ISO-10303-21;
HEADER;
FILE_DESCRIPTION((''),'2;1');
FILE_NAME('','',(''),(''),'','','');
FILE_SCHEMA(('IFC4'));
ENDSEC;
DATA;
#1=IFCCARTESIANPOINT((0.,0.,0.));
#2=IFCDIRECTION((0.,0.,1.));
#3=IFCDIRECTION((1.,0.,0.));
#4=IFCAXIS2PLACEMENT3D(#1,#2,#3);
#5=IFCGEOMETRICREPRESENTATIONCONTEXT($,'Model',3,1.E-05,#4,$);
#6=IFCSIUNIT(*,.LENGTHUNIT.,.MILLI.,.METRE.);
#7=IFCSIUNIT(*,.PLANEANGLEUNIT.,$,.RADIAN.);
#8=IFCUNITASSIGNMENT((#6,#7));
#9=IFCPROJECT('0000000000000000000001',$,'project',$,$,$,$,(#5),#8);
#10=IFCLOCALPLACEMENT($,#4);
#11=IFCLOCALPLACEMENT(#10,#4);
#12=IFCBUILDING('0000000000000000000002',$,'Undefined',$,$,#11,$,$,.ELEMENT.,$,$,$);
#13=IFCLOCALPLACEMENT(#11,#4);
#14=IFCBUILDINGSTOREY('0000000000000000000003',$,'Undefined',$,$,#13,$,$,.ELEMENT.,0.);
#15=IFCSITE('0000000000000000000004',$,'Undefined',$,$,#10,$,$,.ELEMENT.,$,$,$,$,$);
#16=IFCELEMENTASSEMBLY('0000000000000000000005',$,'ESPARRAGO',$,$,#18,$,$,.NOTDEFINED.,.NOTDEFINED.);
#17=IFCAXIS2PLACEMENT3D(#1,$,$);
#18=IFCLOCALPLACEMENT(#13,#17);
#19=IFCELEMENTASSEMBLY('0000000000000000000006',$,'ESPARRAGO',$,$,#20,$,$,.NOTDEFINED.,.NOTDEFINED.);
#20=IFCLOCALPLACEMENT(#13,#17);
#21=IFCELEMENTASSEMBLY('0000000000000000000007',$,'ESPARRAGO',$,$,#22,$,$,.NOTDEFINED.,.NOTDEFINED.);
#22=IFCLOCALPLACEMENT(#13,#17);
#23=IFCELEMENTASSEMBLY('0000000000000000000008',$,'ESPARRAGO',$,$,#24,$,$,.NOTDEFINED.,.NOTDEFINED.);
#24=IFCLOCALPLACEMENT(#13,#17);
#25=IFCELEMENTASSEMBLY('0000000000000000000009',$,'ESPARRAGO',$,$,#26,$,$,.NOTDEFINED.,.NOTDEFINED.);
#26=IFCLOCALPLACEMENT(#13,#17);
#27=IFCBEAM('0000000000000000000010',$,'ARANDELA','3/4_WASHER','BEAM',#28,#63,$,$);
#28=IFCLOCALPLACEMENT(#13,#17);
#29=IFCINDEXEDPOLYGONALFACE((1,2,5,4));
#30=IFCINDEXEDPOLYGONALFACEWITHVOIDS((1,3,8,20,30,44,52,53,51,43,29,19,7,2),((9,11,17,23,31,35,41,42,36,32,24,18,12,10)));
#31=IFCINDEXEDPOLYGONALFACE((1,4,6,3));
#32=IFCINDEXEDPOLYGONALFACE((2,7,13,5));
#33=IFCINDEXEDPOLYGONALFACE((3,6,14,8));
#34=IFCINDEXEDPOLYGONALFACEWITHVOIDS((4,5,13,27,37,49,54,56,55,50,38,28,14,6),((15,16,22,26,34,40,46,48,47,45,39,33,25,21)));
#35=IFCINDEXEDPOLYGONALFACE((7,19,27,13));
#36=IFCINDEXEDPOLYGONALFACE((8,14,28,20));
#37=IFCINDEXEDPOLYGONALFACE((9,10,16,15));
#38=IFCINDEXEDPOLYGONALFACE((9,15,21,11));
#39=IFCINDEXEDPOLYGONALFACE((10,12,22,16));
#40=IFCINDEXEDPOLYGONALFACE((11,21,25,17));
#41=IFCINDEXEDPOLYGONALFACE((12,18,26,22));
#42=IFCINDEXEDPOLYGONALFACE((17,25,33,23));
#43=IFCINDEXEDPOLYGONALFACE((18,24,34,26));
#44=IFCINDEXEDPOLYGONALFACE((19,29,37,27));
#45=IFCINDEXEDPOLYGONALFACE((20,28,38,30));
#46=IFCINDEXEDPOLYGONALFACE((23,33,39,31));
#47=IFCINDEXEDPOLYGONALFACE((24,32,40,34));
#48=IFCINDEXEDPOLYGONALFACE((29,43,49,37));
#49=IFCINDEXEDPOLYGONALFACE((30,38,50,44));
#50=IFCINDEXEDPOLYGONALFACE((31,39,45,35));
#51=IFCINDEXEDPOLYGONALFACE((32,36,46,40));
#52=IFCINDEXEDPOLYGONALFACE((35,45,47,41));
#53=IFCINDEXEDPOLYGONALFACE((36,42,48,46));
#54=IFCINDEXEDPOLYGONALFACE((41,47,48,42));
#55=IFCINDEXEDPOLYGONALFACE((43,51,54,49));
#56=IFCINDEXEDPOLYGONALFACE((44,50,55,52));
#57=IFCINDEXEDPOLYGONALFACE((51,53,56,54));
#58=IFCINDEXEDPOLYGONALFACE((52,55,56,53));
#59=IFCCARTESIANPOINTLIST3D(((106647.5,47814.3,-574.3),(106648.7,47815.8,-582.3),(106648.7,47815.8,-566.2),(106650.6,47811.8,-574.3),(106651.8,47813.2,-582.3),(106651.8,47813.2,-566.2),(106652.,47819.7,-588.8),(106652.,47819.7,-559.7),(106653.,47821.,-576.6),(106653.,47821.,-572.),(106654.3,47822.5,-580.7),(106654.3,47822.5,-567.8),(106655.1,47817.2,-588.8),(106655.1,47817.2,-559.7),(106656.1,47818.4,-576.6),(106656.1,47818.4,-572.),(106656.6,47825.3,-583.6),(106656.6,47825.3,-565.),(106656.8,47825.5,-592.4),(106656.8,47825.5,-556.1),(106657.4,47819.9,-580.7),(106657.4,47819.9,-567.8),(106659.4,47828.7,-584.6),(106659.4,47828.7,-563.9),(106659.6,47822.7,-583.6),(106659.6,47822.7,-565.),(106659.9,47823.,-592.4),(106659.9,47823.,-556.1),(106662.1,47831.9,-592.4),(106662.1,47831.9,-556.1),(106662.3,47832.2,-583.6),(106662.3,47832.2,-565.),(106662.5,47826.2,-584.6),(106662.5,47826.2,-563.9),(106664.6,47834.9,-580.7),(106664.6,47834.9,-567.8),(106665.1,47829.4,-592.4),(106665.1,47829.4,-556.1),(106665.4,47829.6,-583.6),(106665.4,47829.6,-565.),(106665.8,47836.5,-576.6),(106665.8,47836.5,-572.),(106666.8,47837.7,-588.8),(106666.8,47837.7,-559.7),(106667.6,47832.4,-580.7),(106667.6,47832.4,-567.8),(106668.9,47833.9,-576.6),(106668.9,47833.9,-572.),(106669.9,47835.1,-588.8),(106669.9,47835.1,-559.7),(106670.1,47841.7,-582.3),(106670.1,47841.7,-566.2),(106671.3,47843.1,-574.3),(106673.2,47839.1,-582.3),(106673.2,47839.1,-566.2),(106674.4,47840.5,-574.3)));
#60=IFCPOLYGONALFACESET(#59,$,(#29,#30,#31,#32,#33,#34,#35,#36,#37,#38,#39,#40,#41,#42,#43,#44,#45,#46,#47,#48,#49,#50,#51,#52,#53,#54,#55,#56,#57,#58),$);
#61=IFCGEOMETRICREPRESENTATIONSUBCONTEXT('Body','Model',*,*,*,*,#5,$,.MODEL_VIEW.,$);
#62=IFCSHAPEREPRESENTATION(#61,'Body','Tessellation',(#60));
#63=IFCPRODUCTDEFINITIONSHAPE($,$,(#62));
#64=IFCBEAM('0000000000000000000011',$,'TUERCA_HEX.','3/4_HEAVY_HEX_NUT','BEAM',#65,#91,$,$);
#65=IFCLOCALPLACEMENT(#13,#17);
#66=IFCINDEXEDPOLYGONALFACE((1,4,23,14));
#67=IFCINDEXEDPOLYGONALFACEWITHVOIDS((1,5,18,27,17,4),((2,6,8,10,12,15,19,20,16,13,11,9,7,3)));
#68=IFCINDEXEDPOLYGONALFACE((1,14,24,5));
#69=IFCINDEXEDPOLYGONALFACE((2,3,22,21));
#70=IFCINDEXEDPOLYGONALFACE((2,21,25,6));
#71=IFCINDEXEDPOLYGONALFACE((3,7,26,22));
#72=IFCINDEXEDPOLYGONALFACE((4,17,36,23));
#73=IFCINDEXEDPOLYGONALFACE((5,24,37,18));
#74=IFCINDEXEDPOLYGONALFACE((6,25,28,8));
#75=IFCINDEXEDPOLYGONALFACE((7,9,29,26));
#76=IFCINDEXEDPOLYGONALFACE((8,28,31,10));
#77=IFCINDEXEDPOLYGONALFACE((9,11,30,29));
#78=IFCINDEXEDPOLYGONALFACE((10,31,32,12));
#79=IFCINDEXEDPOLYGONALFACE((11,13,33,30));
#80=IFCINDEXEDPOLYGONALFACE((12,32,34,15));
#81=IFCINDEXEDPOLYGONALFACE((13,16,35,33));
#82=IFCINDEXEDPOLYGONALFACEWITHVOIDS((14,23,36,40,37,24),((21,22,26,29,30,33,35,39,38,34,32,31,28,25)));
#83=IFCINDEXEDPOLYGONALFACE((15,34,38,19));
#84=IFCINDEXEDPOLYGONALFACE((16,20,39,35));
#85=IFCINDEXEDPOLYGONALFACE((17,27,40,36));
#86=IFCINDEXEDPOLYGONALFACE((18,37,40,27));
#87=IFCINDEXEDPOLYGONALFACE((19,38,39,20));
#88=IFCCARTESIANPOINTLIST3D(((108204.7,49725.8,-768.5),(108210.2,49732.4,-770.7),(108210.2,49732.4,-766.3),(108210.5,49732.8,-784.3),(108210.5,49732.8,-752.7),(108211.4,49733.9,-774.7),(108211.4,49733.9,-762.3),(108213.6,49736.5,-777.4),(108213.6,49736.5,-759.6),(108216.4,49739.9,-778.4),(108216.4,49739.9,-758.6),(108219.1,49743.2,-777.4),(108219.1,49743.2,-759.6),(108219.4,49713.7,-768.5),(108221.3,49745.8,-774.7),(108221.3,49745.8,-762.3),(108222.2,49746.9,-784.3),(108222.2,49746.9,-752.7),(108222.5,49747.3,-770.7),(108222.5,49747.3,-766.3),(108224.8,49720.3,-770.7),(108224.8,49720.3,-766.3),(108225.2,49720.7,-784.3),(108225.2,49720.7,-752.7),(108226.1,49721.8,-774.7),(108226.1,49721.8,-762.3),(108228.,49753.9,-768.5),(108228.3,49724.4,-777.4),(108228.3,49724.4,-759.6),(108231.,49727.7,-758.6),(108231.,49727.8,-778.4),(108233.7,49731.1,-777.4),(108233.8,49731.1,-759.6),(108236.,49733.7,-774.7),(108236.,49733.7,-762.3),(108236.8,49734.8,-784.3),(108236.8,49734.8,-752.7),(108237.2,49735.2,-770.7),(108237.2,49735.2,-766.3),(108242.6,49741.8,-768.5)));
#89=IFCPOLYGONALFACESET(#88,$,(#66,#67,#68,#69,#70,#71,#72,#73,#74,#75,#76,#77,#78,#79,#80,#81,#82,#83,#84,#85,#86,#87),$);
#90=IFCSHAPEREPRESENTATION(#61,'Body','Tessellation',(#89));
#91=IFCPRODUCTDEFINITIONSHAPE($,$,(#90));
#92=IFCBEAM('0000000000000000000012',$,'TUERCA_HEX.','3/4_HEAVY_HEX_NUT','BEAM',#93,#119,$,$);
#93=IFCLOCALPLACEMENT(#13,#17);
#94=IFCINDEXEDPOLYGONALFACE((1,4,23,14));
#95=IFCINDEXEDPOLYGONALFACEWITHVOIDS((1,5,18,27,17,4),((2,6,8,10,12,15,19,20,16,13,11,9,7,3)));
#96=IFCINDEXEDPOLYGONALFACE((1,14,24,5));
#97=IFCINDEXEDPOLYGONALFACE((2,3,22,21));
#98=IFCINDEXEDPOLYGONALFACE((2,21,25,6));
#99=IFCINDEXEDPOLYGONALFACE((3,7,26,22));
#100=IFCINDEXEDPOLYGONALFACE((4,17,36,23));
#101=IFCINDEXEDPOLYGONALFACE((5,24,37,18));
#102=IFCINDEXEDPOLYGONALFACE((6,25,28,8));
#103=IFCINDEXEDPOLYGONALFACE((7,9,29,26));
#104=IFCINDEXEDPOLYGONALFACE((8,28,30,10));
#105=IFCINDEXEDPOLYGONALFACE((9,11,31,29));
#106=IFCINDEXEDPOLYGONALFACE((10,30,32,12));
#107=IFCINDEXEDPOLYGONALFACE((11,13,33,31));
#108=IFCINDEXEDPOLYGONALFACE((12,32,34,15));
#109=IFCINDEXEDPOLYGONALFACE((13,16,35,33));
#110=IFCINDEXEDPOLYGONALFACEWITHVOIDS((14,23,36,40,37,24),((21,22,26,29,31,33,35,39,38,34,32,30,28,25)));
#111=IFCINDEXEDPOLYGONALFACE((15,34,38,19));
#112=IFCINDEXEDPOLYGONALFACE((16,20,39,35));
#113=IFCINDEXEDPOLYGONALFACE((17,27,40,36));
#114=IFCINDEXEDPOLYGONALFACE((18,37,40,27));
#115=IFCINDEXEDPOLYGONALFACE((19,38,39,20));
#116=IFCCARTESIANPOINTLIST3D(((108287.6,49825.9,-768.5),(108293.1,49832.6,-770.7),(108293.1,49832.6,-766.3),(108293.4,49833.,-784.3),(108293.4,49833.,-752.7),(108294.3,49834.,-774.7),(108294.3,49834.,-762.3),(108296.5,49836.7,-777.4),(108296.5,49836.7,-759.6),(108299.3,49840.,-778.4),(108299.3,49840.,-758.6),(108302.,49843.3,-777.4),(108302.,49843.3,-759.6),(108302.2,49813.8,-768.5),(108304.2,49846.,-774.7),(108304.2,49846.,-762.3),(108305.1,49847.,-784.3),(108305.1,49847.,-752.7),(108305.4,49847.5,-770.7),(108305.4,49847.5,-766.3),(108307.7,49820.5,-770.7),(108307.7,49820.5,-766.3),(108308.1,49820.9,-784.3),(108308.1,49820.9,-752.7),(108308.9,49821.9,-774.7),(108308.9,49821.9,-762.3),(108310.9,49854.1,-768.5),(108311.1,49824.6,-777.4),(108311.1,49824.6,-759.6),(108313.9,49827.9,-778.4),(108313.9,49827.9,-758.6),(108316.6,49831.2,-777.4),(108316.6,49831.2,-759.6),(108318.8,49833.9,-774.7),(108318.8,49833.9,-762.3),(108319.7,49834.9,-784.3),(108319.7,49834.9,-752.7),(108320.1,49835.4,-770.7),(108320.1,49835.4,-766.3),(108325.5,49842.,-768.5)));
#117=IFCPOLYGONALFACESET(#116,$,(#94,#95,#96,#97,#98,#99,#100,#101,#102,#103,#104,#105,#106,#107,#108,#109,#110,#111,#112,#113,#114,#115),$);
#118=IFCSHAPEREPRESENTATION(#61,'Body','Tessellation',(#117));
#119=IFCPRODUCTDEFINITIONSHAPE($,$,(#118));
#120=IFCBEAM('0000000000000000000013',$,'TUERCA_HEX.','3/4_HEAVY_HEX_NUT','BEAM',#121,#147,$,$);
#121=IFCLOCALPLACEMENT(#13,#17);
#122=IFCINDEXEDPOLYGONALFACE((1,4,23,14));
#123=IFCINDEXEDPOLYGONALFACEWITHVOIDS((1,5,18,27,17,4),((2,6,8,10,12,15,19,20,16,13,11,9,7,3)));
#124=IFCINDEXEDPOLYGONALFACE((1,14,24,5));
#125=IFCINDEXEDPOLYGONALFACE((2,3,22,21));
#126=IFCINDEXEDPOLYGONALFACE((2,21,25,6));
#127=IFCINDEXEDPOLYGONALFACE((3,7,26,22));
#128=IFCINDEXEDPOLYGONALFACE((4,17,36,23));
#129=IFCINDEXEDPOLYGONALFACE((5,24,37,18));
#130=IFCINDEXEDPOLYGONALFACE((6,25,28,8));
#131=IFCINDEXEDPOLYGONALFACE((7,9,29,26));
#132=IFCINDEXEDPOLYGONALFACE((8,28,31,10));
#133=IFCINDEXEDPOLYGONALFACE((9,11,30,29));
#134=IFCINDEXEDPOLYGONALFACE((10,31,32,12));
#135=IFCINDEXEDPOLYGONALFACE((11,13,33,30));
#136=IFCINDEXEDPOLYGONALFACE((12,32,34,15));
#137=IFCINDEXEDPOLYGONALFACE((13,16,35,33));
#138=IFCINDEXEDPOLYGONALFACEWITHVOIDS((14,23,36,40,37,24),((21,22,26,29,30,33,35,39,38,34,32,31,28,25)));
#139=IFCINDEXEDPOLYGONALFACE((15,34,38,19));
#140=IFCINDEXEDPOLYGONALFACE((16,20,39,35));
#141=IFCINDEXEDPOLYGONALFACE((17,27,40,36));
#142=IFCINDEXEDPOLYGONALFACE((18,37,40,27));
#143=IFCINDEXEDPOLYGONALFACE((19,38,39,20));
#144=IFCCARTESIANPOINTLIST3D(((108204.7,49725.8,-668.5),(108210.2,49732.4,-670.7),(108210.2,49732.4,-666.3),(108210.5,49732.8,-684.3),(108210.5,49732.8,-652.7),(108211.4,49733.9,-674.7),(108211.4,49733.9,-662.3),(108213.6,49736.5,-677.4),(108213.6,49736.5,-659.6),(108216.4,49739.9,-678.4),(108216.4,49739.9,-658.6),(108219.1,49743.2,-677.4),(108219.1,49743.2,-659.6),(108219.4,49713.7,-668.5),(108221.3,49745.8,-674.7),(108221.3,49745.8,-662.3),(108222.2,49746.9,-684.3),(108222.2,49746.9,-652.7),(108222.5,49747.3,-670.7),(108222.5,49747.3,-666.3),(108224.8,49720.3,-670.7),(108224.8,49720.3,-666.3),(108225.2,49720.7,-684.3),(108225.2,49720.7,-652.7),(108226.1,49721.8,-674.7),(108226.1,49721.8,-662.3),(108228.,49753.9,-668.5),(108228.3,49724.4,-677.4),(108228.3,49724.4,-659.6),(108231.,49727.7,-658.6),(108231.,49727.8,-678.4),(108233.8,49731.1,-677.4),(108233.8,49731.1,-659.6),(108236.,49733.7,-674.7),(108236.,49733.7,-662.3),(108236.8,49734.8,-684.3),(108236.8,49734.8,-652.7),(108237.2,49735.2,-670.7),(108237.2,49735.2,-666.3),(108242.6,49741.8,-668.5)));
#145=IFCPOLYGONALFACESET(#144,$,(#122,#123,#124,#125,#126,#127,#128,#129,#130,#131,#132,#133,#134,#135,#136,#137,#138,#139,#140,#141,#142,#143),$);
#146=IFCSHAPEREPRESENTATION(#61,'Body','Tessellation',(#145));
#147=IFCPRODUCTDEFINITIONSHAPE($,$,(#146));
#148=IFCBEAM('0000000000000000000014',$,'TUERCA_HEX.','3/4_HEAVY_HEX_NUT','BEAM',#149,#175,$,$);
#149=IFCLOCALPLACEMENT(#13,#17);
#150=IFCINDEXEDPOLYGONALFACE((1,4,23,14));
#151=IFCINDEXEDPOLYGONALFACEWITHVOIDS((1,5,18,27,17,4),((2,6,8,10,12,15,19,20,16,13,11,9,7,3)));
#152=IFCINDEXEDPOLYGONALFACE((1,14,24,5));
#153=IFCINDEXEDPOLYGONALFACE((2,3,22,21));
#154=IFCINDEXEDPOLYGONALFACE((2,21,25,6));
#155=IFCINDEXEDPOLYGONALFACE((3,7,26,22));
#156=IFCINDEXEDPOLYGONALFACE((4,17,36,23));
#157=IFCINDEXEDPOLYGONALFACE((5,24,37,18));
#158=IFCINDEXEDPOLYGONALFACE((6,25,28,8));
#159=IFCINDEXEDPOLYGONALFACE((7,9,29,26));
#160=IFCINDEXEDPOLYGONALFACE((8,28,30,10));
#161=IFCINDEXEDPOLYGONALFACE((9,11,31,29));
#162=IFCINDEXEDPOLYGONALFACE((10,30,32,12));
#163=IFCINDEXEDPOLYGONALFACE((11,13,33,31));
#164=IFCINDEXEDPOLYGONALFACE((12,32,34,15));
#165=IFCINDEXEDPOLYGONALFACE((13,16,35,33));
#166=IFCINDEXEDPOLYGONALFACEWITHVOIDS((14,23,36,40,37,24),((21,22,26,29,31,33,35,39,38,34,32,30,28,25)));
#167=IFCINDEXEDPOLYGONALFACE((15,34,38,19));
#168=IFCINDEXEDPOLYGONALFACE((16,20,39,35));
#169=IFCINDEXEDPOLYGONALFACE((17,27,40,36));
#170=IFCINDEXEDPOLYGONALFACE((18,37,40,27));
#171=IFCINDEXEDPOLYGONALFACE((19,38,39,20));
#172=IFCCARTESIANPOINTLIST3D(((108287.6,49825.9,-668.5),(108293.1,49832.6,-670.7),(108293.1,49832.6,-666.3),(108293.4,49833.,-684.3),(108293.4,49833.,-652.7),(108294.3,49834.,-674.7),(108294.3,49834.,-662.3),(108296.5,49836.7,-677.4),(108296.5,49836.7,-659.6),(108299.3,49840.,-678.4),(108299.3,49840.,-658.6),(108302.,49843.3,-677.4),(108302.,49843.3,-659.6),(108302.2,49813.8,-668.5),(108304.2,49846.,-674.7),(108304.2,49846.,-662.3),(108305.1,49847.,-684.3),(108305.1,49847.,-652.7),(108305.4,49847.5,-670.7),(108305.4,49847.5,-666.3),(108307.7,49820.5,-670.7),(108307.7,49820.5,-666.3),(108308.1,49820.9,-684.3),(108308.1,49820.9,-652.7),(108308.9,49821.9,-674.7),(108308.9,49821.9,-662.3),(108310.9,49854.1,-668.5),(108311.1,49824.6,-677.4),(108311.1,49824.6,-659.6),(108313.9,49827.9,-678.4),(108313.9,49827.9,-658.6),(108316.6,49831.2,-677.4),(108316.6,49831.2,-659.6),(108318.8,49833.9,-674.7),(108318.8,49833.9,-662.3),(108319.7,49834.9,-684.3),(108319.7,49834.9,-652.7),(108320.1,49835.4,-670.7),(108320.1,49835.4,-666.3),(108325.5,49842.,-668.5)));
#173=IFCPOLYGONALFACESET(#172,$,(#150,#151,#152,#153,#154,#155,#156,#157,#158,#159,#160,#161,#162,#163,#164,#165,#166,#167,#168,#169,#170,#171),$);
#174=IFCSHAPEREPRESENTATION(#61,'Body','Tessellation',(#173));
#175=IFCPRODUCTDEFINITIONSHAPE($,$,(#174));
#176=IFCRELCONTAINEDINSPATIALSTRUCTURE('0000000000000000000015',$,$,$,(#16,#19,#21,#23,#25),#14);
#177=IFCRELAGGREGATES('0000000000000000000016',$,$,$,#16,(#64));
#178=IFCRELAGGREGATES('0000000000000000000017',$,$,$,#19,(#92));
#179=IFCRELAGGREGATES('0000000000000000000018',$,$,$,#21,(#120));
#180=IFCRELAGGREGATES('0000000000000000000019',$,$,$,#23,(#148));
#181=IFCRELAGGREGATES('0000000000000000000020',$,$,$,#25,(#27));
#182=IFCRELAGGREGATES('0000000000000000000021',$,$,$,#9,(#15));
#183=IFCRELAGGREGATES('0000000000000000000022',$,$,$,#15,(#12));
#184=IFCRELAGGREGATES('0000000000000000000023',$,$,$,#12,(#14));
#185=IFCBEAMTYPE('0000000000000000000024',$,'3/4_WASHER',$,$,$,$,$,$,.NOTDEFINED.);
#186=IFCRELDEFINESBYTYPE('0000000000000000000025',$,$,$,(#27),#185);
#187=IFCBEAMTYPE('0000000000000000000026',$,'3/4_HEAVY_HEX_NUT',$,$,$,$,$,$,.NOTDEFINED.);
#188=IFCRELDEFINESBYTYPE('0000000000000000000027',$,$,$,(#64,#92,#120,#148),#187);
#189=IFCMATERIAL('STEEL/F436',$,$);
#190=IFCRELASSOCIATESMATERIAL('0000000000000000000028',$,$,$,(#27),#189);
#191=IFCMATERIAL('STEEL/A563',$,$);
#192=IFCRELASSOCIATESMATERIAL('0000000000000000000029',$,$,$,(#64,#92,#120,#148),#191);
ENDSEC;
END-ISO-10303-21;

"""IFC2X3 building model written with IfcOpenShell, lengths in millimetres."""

from ifc_helpers import new_model, si_unit, frame, origin_with_axes, place, context, subcontext, project, spatial, polyline, outline, extrude, material, type_object, element, aggregate, save


model = new_model("IFC2X3")

# Units and contexts
model_context = context("Model", 3, precision=1e-05, world=origin_with_axes())
body_context = subcontext(model_context, "Body", "Model", "MODEL_VIEW")
ifc_project = project(units=[si_unit("LENGTHUNIT", "METRE", prefix="MILLI"), si_unit("PLANEANGLEUNIT", "RADIAN")], contexts=[model_context])

# Site, building, storey
site_placement = place(None, origin_with_axes())
site = spatial("IfcSite", under=ifc_project, at=site_placement, Name="Undefined", CompositionType="ELEMENT")
building_placement = place(site_placement, origin_with_axes())
building = spatial("IfcBuilding", under=site, at=building_placement, Name="Undefined", CompositionType="ELEMENT")
storey_placement = place(building_placement, origin_with_axes())
storey = spatial("IfcBuildingStorey", under=building, at=storey_placement, Name="Undefined", CompositionType="ELEMENT", Elevation=0.0)

# Element assemblies, beam
ifc_material_1 = material(Name="STEEL/F436")
beam_type_1 = type_object("IfcBeamType", Name="3/4_WASHER", PredefinedType="NOTDEFINED")
assembly_1_placement = place(storey_placement, origin_with_axes())
assembly_1 = element("IfcElementAssembly", 1, at=assembly_1_placement, inside=storey, Name="ESPARRAGO", AssemblyPlace="NOTDEFINED", PredefinedType="NOTDEFINED")
assembly_2_placement = place(storey_placement, origin_with_axes())
assembly_2 = element("IfcElementAssembly", 2, at=assembly_2_placement, inside=storey, Name="ESPARRAGO", AssemblyPlace="NOTDEFINED", PredefinedType="NOTDEFINED")
assembly_3_placement = place(storey_placement, origin_with_axes())
assembly_3 = element("IfcElementAssembly", 3, at=assembly_3_placement, inside=storey, Name="ESPARRAGO", AssemblyPlace="NOTDEFINED", PredefinedType="NOTDEFINED")
assembly_4_placement = place(storey_placement, origin_with_axes())
assembly_4 = element("IfcElementAssembly", 4, at=assembly_4_placement, inside=storey, Name="ESPARRAGO", AssemblyPlace="NOTDEFINED", PredefinedType="NOTDEFINED")
assembly_5_placement = place(storey_placement, origin_with_axes())
assembly_5 = element("IfcElementAssembly", 5, at=assembly_5_placement, inside=storey, Name="ESPARRAGO", AssemblyPlace="NOTDEFINED", PredefinedType="NOTDEFINED")
beam_1_placement = place(assembly_5_placement, frame((106659.4, 47828.7, -574.3), z_axis=(0.000066, -0.000055, 1.0), x_axis=(0.7704, -0.637561, -0.000086)))
beam_1 = element("IfcBeam", 6, at=beam_1_placement, type_object=beam_type_1, material=ifc_material_1, Name="ARANDELA", Description="3/4_WASHER", ObjectType="BEAM", context=body_context, shape_type="SweptSolid", body=[
    extrude(outline(polyline([(-11.6, -14.6), (-16.8, -8.1), (-18.6, 0.0), (-16.8, 8.1), (-11.6, 14.6), (-4.2, 18.2), (4.2, 18.2), (11.6, 14.6), (16.8, 8.1), (18.6, 0.0), (16.8, -8.1), (11.6, -14.6), (4.2, -18.2), (-4.2, -18.2), (-11.6, -14.6)]), holes=[polyline([(-4.5, 9.3), (-8.1, 6.4), (-10.1, 2.3), (-10.1, -2.3), (-8.1, -6.4), (-4.5, -9.3), (0.0, -10.3), (4.5, -9.3), (8.1, -6.4), (10.1, -2.3), (10.1, 2.3), (8.1, 6.4), (4.5, 9.3), (0.0, 10.3), (-4.5, 9.3)])]), frame((4.0, 0.0, 0.0), z_axis=(-1.0, 0.0, 0.0), x_axis=(0.0, -1.0, 0.0)), (0.0, 0.0, 1.0), 4.0),
])

# Beams
ifc_material_2 = material(Name="STEEL/A563")
beam_type_2 = type_object("IfcBeamType", Name="3/4_HEAVY_HEX_NUT", PredefinedType="NOTDEFINED")
beam_2_placement = place(assembly_1_placement, frame((108216.4, 49739.9, -768.5), z_axis=(0.000012, -0.00001, 1.0), x_axis=(0.7704, -0.637561, -0.000016)))
beam_2 = element("IfcBeam", 7, at=beam_2_placement, type_object=beam_type_2, material=ifc_material_2, Name="TUERCA_HEX.", Description="3/4_HEAVY_HEX_NUT", ObjectType="BEAM", context=body_context, shape_type="SweptSolid", body=[
    extrude(outline(polyline([(9.1, -15.8), (-9.1, -15.8), (-18.3, 0.0), (-9.1, 15.8), (9.1, 15.8), (18.3, 0.0), (9.1, -15.8)]), holes=[polyline([(-4.3, 8.9), (-7.8, 6.2), (-9.7, 2.2), (-9.7, -2.2), (-7.8, -6.2), (-4.3, -8.9), (0.0, -9.9), (4.3, -8.9), (7.8, -6.2), (9.7, -2.2), (9.7, 2.2), (7.8, 6.2), (4.3, 8.9), (0.0, 9.9), (-4.3, 8.9)])]), frame((19.0, 0.0, 0.0), z_axis=(-1.0, 0.0, 0.0), x_axis=(0.0, -1.0, 0.0)), (0.0, 0.0, 1.0), 19.0),
])
beam_3_placement = place(assembly_2_placement, frame((108299.3, 49840.0, -768.5), z_axis=(0.000012, -0.00001, 1.0), x_axis=(0.7704, -0.637561, -0.000016)))
beam_3 = element("IfcBeam", 8, at=beam_3_placement, type_object=beam_type_2, material=ifc_material_2, Name="TUERCA_HEX.", Description="3/4_HEAVY_HEX_NUT", ObjectType="BEAM", context=body_context, shape_type="SweptSolid", body=[
    extrude(outline(polyline([(9.1, -15.8), (-9.1, -15.8), (-18.3, 0.0), (-9.1, 15.8), (9.1, 15.8), (18.3, 0.0), (9.1, -15.8)]), holes=[polyline([(-4.3, 8.9), (-7.8, 6.2), (-9.7, 2.2), (-9.7, -2.2), (-7.8, -6.2), (-4.3, -8.9), (0.0, -9.9), (4.3, -8.9), (7.8, -6.2), (9.7, -2.2), (9.7, 2.2), (7.8, 6.2), (4.3, 8.9), (0.0, 9.9), (-4.3, 8.9)])]), frame((19.0, 0.0, 0.0), z_axis=(-1.0, 0.0, 0.0), x_axis=(0.0, -1.0, 0.0)), (0.0, 0.0, 1.0), 19.0),
])
beam_4_placement = place(assembly_3_placement, frame((108216.4, 49739.9, -668.5), z_axis=(0.000012, -0.00001, 1.0), x_axis=(0.7704, -0.637561, -0.000016)))
beam_4 = element("IfcBeam", 9, at=beam_4_placement, type_object=beam_type_2, material=ifc_material_2, Name="TUERCA_HEX.", Description="3/4_HEAVY_HEX_NUT", ObjectType="BEAM", context=body_context, shape_type="SweptSolid", body=[
    extrude(outline(polyline([(9.1, -15.8), (-9.1, -15.8), (-18.3, 0.0), (-9.1, 15.8), (9.1, 15.8), (18.3, 0.0), (9.1, -15.8)]), holes=[polyline([(-4.3, 8.9), (-7.8, 6.2), (-9.7, 2.2), (-9.7, -2.2), (-7.8, -6.2), (-4.3, -8.9), (0.0, -9.9), (4.3, -8.9), (7.8, -6.2), (9.7, -2.2), (9.7, 2.2), (7.8, 6.2), (4.3, 8.9), (0.0, 9.9), (-4.3, 8.9)])]), frame((19.0, 0.0, 0.0), z_axis=(-1.0, 0.0, 0.0), x_axis=(0.0, -1.0, 0.0)), (0.0, 0.0, 1.0), 19.0),
])
beam_5_placement = place(assembly_4_placement, frame((108299.3, 49840.0, -668.5), z_axis=(0.000012, -0.00001, 1.0), x_axis=(0.7704, -0.637561, -0.000016)))
beam_5 = element("IfcBeam", 10, at=beam_5_placement, type_object=beam_type_2, material=ifc_material_2, Name="TUERCA_HEX.", Description="3/4_HEAVY_HEX_NUT", ObjectType="BEAM", context=body_context, shape_type="SweptSolid", body=[
    extrude(outline(polyline([(9.1, -15.8), (-9.1, -15.8), (-18.3, 0.0), (-9.1, 15.8), (9.1, 15.8), (18.3, 0.0), (9.1, -15.8)]), holes=[polyline([(-4.3, 8.9), (-7.8, 6.2), (-9.7, 2.2), (-9.7, -2.2), (-7.8, -6.2), (-4.3, -8.9), (0.0, -9.9), (4.3, -8.9), (7.8, -6.2), (9.7, -2.2), (9.7, 2.2), (7.8, 6.2), (4.3, 8.9), (0.0, 9.9), (-4.3, 8.9)])]), frame((19.0, 0.0, 0.0), z_axis=(-1.0, 0.0, 0.0), x_axis=(0.0, -1.0, 0.0)), (0.0, 0.0, 1.0), 19.0),
])

aggregate(assembly_1, [beam_2])
aggregate(assembly_2, [beam_3])
aggregate(assembly_3, [beam_4])
aggregate(assembly_4, [beam_5])
aggregate(assembly_5, [beam_1])

save(model, "model.ifc")
